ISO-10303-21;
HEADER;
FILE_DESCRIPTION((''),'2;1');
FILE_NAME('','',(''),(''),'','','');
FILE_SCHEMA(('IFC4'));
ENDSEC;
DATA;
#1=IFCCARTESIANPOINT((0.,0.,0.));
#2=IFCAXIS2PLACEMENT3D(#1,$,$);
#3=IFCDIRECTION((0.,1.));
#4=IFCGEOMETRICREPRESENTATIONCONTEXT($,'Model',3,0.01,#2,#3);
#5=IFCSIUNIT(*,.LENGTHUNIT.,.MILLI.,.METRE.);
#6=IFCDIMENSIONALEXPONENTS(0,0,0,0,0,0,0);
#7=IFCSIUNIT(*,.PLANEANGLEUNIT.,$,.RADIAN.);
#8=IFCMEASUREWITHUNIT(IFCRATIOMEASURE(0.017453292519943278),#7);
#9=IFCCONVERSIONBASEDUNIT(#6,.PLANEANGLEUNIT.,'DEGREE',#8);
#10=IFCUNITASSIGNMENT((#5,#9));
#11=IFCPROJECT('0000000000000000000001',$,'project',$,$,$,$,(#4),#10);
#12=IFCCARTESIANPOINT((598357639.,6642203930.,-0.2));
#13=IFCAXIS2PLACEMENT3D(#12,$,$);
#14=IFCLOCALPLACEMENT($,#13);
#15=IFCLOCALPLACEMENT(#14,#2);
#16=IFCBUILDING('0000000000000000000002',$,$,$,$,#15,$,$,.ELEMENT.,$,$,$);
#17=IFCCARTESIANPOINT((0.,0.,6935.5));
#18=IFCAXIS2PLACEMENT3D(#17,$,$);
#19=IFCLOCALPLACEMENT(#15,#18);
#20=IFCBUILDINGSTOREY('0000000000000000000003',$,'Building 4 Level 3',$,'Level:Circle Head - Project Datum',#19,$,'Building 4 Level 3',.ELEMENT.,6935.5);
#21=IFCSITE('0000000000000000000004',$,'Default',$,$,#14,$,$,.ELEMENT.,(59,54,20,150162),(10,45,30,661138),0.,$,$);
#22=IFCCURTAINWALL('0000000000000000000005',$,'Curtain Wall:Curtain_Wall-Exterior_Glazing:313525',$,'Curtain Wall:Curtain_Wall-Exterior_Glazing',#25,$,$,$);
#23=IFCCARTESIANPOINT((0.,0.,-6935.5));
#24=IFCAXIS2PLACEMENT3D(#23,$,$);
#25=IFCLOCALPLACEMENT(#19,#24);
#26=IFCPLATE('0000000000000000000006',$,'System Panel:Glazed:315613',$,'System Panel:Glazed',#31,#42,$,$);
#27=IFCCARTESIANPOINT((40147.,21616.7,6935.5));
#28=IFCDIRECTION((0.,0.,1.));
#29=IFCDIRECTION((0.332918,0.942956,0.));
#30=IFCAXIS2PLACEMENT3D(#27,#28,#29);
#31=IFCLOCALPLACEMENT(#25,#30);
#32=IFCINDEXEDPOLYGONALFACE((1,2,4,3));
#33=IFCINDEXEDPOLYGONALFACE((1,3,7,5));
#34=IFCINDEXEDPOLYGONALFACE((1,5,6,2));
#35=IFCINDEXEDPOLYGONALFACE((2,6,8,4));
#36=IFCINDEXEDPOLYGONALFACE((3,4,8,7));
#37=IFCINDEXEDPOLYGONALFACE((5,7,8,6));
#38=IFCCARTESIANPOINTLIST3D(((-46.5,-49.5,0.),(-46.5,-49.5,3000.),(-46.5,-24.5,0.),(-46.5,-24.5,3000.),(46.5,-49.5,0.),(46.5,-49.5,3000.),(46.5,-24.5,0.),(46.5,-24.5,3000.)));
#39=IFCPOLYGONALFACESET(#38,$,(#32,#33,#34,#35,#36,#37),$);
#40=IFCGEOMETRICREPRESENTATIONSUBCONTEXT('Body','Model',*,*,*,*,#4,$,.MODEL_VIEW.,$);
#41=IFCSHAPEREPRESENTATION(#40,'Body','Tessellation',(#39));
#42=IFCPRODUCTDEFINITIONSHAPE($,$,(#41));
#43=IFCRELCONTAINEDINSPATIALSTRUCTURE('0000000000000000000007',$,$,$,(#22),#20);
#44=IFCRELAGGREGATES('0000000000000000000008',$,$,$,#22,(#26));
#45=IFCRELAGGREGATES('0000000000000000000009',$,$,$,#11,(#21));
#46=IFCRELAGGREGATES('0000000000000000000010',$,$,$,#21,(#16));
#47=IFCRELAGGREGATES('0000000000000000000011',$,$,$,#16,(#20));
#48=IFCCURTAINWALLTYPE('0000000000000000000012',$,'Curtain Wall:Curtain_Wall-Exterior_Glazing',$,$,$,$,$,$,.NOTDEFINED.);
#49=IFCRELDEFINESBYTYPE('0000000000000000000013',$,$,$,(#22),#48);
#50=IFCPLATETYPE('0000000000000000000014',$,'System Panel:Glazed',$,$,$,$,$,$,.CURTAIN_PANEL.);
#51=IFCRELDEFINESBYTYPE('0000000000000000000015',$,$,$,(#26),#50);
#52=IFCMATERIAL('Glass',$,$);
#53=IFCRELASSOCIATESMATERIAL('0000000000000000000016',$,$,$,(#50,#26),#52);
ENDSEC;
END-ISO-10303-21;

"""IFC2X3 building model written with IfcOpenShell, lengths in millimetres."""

from ifc_helpers import new_model, entity, si_unit, converted_unit, direction, frame, frame_2d, origin, place, context, subcontext, project, spatial, rectangle, extrude, source, transform, mapped, material, type_object, type_shapes, element, aggregate, save


model = new_model("IFC2X3")

# Units and contexts
model_context = context("Model", 3, precision=0.01, world=origin(), true_north=direction((0.0, 1.0)))
body_context = subcontext(model_context, "Body", "Model", "MODEL_VIEW")
ifc_project = project(units=[si_unit("LENGTHUNIT", "METRE", prefix="MILLI"), converted_unit("PLANEANGLEUNIT", "DEGREE", entity("IfcRatioMeasure", 0.017453292519943278), si_unit("PLANEANGLEUNIT", "RADIAN"), dimensions=[0, 0, 0, 0, 0, 0, 0])], contexts=[model_context])

# Site, building, storey
site_placement = place(None, frame((598357639.0, 6642203930.0, -0.2)))
site = spatial("IfcSite", under=ifc_project, at=site_placement, Name="Default", CompositionType="ELEMENT", RefLatitude=(59, 54, 20, 150162), RefLongitude=(10, 45, 30, 661138), RefElevation=0.0)
building_placement = place(site_placement, origin())
building = spatial("IfcBuilding", under=site, at=building_placement, CompositionType="ELEMENT")
storey_placement = place(building_placement, frame((0.0, 0.0, 6935.5)))
storey = spatial("IfcBuildingStorey", under=building, at=storey_placement, Name="Building 4 Level 3", ObjectType="Level:Circle Head - Project Datum", LongName="Building 4 Level 3", CompositionType="ELEMENT", Elevation=6935.5)

# Curtain wall, plate
curtain_wall_type = type_object("IfcCurtainWallType", Name="Curtain Wall:Curtain_Wall-Exterior_Glazing", PredefinedType="NOTDEFINED")
curtain_wall_placement = place(storey_placement, frame((0.0, 0.0, -6935.5)))
curtain_wall = element("IfcCurtainWall", 1, at=curtain_wall_placement, inside=storey, type_object=curtain_wall_type, Name="Curtain Wall:Curtain_Wall-Exterior_Glazing:313525", ObjectType="Curtain Wall:Curtain_Wall-Exterior_Glazing")
ifc_material_1 = material(Name="Glass")
plate_type_1 = type_object("IfcPlateType", Name="System Panel:Glazed", PredefinedType="CURTAIN_PANEL", material=ifc_material_1)
shared_shape_1 = source(origin(), body_context, "Body", "SweptSolid", [
    extrude(rectangle(XDim=25.0, YDim=93.1, at=frame_2d((0.0, 0.0), x_axis=(1.0, 0.0))), frame((0.0, -37.0, 0.0), z_axis=(0.0, 0.0, 1.0), x_axis=(0.0, 1.0, 0.0)), (0.0, 0.0, 1.0), 3000.0),
])
type_shapes(plate_type_1, [shared_shape_1])
plate_1_placement = place(curtain_wall_placement, frame((40147.0, 21616.7, 6935.5), z_axis=(0.0, 0.0, 1.0), x_axis=(0.332918, 0.942956, 0.0)))
plate_1 = element("IfcPlate", 2, at=plate_1_placement, type_object=plate_type_1, material=ifc_material_1, Name="System Panel:Glazed:315613", ObjectType="System Panel:Glazed", context=body_context, shape_type="MappedRepresentation", body=[
    mapped(shared_shape_1, transform((0.0, 0.0, 0.0), scale=1.0)),
])
aggregate(curtain_wall, [plate_1])

save(model, "model.ifc")
